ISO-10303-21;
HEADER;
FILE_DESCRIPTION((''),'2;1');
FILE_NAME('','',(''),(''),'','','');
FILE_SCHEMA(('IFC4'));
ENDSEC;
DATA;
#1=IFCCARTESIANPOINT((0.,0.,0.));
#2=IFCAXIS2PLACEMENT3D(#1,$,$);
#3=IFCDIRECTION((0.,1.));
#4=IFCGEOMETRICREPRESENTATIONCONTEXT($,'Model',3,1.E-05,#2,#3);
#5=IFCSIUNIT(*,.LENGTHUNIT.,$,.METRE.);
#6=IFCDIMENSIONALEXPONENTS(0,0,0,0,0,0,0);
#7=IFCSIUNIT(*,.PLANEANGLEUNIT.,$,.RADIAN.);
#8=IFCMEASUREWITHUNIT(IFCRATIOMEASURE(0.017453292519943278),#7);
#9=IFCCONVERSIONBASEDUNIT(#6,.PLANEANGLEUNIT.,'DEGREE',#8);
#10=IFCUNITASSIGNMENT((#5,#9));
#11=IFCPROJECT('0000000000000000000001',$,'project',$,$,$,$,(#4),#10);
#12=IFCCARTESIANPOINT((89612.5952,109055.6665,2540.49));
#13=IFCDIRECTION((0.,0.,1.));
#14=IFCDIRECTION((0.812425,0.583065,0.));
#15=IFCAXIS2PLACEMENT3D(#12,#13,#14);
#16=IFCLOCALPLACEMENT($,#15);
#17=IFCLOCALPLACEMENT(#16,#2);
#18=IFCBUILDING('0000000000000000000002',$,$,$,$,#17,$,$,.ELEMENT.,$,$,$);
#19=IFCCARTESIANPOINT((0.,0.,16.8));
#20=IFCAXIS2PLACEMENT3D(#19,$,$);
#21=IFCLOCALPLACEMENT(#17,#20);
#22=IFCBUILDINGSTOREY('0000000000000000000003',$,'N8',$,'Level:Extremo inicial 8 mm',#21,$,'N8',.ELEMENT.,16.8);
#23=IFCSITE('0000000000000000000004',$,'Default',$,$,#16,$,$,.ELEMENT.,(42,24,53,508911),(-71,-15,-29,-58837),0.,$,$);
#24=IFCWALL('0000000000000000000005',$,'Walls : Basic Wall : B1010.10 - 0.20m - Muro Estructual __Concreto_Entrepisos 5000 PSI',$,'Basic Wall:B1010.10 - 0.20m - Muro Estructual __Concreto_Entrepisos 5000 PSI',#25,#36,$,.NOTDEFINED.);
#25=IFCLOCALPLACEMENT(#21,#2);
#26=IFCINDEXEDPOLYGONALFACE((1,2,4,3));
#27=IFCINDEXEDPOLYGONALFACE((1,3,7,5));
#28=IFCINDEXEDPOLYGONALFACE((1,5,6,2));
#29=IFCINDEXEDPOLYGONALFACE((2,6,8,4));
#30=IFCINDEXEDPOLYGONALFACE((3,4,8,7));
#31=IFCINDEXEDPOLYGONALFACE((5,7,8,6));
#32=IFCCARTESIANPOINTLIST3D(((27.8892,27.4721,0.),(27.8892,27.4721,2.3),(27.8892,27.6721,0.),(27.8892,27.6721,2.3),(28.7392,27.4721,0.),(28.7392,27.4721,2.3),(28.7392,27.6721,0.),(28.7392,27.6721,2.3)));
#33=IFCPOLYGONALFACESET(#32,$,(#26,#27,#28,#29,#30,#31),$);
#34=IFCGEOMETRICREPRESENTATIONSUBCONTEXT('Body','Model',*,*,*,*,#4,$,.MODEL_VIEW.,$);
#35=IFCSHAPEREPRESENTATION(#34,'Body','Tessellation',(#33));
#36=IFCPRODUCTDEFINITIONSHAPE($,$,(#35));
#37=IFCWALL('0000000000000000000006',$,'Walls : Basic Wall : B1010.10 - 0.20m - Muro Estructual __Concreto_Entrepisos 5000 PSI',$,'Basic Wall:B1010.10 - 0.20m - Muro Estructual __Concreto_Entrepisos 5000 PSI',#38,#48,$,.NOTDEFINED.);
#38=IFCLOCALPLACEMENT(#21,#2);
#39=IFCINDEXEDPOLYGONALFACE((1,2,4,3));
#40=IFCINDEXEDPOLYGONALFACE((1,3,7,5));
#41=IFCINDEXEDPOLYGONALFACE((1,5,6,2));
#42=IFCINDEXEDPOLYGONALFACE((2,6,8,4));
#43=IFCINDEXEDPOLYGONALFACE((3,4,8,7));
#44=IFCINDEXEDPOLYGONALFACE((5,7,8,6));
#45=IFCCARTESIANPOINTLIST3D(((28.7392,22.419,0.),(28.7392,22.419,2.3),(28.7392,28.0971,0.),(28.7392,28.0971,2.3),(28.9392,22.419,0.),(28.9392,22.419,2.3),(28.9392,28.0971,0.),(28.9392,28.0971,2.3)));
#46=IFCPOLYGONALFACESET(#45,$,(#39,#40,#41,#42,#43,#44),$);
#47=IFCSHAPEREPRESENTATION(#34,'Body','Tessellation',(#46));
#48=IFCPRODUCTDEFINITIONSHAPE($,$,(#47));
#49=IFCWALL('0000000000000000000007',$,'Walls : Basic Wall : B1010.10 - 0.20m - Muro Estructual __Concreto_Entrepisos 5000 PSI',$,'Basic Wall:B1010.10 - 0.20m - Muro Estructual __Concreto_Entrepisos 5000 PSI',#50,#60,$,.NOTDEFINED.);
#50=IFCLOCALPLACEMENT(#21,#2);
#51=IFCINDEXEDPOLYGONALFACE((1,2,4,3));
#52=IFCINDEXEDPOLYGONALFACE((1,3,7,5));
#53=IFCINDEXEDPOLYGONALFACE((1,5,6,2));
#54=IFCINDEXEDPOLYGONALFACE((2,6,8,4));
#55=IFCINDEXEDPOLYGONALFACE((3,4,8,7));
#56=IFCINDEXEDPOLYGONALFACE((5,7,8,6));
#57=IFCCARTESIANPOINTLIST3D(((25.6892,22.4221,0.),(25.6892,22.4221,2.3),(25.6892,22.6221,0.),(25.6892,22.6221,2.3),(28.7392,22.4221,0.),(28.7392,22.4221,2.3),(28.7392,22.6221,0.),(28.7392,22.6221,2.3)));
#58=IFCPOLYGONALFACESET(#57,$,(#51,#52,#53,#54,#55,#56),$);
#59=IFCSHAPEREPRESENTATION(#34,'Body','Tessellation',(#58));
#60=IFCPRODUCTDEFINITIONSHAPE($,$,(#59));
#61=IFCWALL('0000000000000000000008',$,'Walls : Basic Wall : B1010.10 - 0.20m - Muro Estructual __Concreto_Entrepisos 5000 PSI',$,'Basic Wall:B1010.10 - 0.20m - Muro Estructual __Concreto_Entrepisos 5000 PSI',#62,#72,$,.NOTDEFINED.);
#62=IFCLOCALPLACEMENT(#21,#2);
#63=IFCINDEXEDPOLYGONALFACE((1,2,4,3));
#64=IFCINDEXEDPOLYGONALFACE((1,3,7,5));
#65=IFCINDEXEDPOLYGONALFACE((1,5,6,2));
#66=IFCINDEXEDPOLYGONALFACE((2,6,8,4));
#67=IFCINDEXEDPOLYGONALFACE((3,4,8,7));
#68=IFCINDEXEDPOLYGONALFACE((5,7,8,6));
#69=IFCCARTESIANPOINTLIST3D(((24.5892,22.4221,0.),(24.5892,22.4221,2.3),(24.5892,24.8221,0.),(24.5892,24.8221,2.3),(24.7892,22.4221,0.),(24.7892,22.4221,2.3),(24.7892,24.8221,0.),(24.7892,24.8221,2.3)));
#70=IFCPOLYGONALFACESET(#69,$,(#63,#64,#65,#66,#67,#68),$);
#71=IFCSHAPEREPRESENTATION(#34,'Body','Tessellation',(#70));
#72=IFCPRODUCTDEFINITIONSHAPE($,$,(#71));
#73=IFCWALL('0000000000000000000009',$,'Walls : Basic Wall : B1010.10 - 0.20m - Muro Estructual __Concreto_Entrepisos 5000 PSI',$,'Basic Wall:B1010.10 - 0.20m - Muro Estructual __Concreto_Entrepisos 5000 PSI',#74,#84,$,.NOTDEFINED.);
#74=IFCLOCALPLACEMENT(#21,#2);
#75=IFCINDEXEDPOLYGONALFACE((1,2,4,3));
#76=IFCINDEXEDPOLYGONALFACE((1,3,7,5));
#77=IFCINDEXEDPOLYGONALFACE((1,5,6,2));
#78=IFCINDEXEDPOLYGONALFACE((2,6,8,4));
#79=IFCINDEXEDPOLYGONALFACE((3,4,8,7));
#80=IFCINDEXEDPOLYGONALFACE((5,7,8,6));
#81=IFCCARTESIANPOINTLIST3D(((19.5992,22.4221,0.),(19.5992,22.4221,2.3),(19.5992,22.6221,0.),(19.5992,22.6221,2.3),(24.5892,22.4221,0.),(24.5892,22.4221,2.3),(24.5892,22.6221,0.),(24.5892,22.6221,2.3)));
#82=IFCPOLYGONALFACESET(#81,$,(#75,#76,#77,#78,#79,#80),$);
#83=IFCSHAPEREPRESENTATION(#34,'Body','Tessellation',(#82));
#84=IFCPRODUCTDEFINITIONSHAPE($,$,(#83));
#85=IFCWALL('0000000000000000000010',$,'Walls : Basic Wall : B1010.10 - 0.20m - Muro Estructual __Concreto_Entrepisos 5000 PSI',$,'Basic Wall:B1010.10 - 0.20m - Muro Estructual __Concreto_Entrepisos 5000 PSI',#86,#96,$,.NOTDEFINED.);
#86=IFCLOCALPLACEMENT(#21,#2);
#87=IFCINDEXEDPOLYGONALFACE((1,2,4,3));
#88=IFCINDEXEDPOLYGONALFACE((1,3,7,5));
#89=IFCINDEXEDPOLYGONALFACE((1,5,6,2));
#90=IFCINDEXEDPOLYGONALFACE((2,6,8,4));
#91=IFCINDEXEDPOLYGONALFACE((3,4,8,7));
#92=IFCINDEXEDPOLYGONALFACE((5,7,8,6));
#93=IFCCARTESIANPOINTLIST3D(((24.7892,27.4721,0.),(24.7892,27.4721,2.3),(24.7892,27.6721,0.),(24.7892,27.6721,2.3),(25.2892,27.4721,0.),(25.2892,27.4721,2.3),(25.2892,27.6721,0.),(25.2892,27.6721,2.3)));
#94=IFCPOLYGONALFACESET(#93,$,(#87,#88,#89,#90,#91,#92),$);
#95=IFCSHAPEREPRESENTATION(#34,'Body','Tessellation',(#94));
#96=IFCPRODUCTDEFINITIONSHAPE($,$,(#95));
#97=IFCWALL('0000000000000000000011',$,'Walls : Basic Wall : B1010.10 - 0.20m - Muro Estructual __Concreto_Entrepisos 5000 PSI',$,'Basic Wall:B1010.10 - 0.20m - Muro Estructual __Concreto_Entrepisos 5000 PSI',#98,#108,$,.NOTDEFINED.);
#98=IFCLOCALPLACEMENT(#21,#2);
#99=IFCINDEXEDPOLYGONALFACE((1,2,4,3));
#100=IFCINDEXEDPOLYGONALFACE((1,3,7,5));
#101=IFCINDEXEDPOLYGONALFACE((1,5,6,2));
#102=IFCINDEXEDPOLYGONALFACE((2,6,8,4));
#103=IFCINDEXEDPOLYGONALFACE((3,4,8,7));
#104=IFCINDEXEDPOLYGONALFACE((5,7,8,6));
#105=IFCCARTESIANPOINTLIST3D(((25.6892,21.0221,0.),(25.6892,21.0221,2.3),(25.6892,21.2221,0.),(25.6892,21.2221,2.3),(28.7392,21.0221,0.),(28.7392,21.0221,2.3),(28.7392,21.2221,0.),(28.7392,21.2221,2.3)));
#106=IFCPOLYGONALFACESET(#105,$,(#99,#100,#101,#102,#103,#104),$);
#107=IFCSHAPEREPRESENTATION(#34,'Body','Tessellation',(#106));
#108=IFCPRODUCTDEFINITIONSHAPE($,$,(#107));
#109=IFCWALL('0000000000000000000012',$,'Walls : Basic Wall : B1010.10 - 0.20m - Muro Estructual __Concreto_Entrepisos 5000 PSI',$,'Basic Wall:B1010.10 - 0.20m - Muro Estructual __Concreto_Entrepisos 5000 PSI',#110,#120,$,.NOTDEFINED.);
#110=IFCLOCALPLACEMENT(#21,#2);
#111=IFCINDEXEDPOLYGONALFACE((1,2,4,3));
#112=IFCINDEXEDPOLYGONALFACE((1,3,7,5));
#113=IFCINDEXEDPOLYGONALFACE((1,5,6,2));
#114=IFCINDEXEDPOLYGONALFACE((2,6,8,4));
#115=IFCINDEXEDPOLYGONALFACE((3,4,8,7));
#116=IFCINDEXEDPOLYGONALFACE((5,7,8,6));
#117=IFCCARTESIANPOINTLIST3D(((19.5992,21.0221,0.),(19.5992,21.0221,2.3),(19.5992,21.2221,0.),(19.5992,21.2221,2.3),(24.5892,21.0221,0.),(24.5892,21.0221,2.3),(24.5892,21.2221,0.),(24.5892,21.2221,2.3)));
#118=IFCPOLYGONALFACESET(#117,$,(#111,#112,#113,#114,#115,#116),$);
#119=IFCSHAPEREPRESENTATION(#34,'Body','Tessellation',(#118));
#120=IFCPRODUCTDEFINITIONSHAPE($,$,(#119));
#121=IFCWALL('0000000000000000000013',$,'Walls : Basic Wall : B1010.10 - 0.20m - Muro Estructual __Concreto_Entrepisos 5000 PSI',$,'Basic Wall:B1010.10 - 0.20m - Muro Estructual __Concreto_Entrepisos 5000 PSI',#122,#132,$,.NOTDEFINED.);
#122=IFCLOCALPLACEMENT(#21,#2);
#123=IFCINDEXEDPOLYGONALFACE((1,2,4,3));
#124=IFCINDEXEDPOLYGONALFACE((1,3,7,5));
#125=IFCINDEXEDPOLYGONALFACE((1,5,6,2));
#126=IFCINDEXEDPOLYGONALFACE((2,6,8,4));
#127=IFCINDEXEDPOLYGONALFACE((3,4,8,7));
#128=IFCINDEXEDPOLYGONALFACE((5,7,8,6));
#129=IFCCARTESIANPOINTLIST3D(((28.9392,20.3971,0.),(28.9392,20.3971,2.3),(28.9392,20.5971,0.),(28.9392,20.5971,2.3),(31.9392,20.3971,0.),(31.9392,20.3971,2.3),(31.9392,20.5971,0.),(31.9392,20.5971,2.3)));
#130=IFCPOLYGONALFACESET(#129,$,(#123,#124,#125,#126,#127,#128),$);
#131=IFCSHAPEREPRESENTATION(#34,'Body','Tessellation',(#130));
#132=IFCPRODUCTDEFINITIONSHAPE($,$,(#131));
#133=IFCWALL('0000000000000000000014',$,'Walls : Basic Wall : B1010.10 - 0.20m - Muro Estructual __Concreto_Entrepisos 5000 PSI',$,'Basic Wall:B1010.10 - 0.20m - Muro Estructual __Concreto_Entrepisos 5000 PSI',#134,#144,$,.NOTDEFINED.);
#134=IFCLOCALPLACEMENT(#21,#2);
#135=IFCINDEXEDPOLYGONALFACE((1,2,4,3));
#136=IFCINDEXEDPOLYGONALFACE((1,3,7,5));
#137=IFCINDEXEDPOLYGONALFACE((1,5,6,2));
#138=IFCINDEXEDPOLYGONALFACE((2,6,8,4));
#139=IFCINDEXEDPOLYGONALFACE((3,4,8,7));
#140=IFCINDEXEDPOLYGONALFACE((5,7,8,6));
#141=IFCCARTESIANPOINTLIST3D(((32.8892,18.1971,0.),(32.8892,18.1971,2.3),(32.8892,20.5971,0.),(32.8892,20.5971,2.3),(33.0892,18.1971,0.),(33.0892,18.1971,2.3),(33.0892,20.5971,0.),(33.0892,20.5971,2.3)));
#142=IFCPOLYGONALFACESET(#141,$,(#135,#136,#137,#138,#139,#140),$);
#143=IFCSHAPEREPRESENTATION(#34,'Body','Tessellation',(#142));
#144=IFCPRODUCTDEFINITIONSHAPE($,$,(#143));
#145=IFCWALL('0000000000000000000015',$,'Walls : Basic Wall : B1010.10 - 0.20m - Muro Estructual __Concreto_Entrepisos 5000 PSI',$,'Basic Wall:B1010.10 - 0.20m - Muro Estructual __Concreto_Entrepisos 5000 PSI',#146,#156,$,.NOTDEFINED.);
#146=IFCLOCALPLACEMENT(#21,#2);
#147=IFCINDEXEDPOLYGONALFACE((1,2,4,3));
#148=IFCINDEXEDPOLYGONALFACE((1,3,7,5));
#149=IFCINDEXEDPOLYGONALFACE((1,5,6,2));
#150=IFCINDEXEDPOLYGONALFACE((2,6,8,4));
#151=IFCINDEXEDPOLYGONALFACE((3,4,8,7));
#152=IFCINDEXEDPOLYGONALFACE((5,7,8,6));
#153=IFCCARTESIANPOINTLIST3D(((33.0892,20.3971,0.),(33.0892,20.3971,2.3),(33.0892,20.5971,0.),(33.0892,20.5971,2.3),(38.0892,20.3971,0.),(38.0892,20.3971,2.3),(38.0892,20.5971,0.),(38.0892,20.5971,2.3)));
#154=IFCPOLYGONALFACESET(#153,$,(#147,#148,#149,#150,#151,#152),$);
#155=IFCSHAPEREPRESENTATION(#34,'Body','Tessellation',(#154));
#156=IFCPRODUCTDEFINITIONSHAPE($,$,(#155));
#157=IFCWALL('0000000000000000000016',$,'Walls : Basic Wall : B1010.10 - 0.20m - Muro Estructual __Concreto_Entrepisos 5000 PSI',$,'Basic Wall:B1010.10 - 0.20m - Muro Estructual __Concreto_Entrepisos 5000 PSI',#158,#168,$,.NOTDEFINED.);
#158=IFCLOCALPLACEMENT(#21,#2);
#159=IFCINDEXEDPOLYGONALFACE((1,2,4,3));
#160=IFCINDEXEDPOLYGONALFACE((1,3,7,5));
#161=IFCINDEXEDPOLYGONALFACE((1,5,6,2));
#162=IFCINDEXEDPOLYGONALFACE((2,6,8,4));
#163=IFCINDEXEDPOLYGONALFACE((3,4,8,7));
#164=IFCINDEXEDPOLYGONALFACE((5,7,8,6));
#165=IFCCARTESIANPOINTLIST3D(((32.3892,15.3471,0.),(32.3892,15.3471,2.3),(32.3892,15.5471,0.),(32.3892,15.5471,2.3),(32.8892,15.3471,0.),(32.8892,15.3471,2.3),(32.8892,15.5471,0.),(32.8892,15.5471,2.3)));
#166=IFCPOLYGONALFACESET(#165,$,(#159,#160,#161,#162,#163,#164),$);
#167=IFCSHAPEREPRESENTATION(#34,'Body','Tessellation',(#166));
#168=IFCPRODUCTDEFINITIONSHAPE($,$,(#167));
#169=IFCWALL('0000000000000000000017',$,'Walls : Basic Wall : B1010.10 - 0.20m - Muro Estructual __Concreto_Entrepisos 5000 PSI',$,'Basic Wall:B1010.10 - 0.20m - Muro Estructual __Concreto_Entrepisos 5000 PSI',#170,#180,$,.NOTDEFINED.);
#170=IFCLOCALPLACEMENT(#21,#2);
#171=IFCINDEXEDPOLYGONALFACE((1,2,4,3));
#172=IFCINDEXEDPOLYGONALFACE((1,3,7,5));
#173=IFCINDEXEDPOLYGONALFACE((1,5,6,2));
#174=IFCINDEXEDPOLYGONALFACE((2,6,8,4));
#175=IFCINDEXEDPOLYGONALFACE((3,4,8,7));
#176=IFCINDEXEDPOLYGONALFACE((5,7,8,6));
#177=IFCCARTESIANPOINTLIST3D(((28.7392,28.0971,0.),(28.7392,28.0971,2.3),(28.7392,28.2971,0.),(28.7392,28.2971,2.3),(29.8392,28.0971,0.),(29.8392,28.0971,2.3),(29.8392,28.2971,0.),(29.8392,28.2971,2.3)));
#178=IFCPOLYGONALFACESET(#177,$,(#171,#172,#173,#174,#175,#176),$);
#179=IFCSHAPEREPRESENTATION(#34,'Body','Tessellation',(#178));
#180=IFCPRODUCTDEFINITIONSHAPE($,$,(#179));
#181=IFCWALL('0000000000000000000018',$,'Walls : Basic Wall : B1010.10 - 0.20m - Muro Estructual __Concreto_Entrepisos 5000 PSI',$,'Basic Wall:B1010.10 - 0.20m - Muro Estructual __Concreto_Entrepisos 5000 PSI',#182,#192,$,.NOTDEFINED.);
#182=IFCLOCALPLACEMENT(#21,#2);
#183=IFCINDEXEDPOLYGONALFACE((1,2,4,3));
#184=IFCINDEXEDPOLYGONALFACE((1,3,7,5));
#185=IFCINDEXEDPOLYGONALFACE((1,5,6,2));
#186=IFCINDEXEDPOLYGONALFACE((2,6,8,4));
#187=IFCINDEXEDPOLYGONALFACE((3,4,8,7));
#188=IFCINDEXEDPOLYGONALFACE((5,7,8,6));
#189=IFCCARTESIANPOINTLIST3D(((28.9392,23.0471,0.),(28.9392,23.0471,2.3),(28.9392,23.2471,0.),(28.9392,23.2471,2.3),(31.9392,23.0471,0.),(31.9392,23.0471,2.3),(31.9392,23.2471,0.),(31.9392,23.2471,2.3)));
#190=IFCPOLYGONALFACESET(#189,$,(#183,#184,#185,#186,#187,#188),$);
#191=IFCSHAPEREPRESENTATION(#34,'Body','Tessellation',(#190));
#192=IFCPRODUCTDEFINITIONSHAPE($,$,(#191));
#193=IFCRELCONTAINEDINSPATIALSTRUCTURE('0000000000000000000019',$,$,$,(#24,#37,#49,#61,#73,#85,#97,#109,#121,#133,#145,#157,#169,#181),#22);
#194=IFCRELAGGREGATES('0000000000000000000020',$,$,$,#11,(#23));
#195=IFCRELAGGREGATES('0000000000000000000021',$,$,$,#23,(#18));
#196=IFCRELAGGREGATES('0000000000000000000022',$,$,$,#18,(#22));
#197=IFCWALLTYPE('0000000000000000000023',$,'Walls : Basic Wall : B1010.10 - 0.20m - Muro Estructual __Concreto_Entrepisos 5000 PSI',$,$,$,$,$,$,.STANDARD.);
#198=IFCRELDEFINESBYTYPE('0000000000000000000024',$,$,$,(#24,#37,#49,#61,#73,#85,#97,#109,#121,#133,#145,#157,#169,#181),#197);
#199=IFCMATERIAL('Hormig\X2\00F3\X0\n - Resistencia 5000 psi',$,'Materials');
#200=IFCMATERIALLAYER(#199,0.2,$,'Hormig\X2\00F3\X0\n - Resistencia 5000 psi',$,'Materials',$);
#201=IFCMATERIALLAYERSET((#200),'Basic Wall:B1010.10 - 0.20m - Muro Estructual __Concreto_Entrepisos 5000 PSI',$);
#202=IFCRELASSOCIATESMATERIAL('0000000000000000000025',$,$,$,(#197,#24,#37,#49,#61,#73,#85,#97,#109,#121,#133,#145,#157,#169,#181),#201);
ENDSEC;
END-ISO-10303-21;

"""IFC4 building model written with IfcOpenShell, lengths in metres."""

from ifc_helpers import new_model, entity, si_unit, converted_unit, direction, frame, frame_2d, origin, place, context, subcontext, project, spatial, rectangle, extrude, material, layer, layer_set, layer_usage, type_object, element, save


model = new_model("IFC4")

# Units and contexts
model_context = context("Model", 3, precision=1e-05, world=origin(), true_north=direction((0.0, 1.0)))
body_context = subcontext(model_context, "Body", "Model", "MODEL_VIEW")
ifc_project = project(units=[si_unit("LENGTHUNIT", "METRE"), converted_unit("PLANEANGLEUNIT", "DEGREE", entity("IfcRatioMeasure", 0.017453292519943278), si_unit("PLANEANGLEUNIT", "RADIAN"), dimensions=[0, 0, 0, 0, 0, 0, 0])], contexts=[model_context])

# Site, building, storey
site_placement = place(None, frame((89612.5952, 109055.6665, 2540.49), z_axis=(0.0, 0.0, 1.0), x_axis=(0.812425, 0.583065, 0.0)))
site = spatial("IfcSite", under=ifc_project, at=site_placement, Name="Default", CompositionType="ELEMENT", RefLatitude=(42, 24, 53, 508911), RefLongitude=(-71, -15, -29, -58837), RefElevation=0.0)
building_placement = place(site_placement, origin())
building = spatial("IfcBuilding", under=site, at=building_placement, CompositionType="ELEMENT")
storey_placement = place(building_placement, frame((0.0, 0.0, 16.8)))
storey = spatial("IfcBuildingStorey", under=building, at=storey_placement, Name="N8", ObjectType="Level:Extremo inicial 8 mm", LongName="N8", CompositionType="ELEMENT", Elevation=16.8)

# Walls
ifc_material = material(Name="Hormigón - Resistencia 5000 psi", Category="Materials")
ifc_layer_1 = layer(ifc_material, 0.2, Name="Hormigón - Resistencia 5000 psi", Category="Materials")
ifc_layer_set_1 = layer_set([ifc_layer_1], Name="Basic Wall:B1010.10 - 0.20m - Muro Estructual __Concreto_Entrepisos 5000 PSI")
ifc_layer_usage_1 = layer_usage(ifc_layer_set_1, "AXIS2", "NEGATIVE", 0.1)
wall_type_1 = type_object("IfcWallType", Name="Walls : Basic Wall : B1010.10 - 0.20m - Muro Estructual __Concreto_Entrepisos 5000 PSI", PredefinedType="STANDARD", material=ifc_layer_set_1)
wall_1_placement = place(storey_placement, frame((27.8892, 27.5721, 0.0)))
element("IfcWall", 1, at=wall_1_placement, inside=storey, type_object=wall_type_1, material=ifc_layer_usage_1, Name="Walls : Basic Wall : B1010.10 - 0.20m - Muro Estructual __Concreto_Entrepisos 5000 PSI", ObjectType="Basic Wall:B1010.10 - 0.20m - Muro Estructual __Concreto_Entrepisos 5000 PSI", PredefinedType="NOTDEFINED", context=body_context, shape_type="SweptSolid", body=[
    extrude(rectangle(XDim=0.85, YDim=0.2, at=frame_2d((0.425, 0.0), x_axis=(-1.0, 0.0))), origin(), (0.0, 0.0, 1.0), 2.3),
])
ifc_layer_usage_2 = layer_usage(ifc_layer_set_1, "AXIS2", "NEGATIVE", 0.1)
wall_2_placement = place(storey_placement, frame((28.8392, 28.0971, 0.0), z_axis=(0.0, 0.0, 1.0), x_axis=(0.0, -1.0, 0.0)))
element("IfcWall", 2, at=wall_2_placement, inside=storey, type_object=wall_type_1, material=ifc_layer_usage_2, Name="Walls : Basic Wall : B1010.10 - 0.20m - Muro Estructual __Concreto_Entrepisos 5000 PSI", ObjectType="Basic Wall:B1010.10 - 0.20m - Muro Estructual __Concreto_Entrepisos 5000 PSI", PredefinedType="NOTDEFINED", context=body_context, shape_type="SweptSolid", body=[
    extrude(rectangle(XDim=5.6781, YDim=0.2, at=frame_2d((2.839, 0.0), x_axis=(-1.0, 0.0))), origin(), (0.0, 0.0, 1.0), 2.3),
])
ifc_layer_usage_3 = layer_usage(ifc_layer_set_1, "AXIS2", "NEGATIVE", 0.1)
wall_3_placement = place(storey_placement, frame((28.7392, 22.5221, 0.0), z_axis=(0.0, 0.0, 1.0), x_axis=(-1.0, 0.0, 0.0)))
element("IfcWall", 3, at=wall_3_placement, inside=storey, type_object=wall_type_1, material=ifc_layer_usage_3, Name="Walls : Basic Wall : B1010.10 - 0.20m - Muro Estructual __Concreto_Entrepisos 5000 PSI", ObjectType="Basic Wall:B1010.10 - 0.20m - Muro Estructual __Concreto_Entrepisos 5000 PSI", PredefinedType="NOTDEFINED", context=body_context, shape_type="SweptSolid", body=[
    extrude(rectangle(XDim=3.05, YDim=0.2, at=frame_2d((1.525, 0.0), x_axis=(-1.0, 0.0))), origin(), (0.0, 0.0, 1.0), 2.3),
])
ifc_layer_usage_4 = layer_usage(ifc_layer_set_1, "AXIS2", "NEGATIVE", 0.1)
wall_4_placement = place(storey_placement, frame((24.6892, 24.8221, 0.0), z_axis=(0.0, 0.0, 1.0), x_axis=(0.0, -1.0, 0.0)))
element("IfcWall", 4, at=wall_4_placement, inside=storey, type_object=wall_type_1, material=ifc_layer_usage_4, Name="Walls : Basic Wall : B1010.10 - 0.20m - Muro Estructual __Concreto_Entrepisos 5000 PSI", ObjectType="Basic Wall:B1010.10 - 0.20m - Muro Estructual __Concreto_Entrepisos 5000 PSI", PredefinedType="NOTDEFINED", context=body_context, shape_type="SweptSolid", body=[
    extrude(rectangle(XDim=2.4, YDim=0.2, at=frame_2d((1.2, 0.0), x_axis=(-1.0, 0.0))), origin(), (0.0, 0.0, 1.0), 2.3),
])
ifc_layer_usage_5 = layer_usage(ifc_layer_set_1, "AXIS2", "NEGATIVE", 0.1)
wall_5_placement = place(storey_placement, frame((24.5892, 22.5221, 0.0), z_axis=(0.0, 0.0, 1.0), x_axis=(-1.0, 0.0, 0.0)))
element("IfcWall", 5, at=wall_5_placement, inside=storey, type_object=wall_type_1, material=ifc_layer_usage_5, Name="Walls : Basic Wall : B1010.10 - 0.20m - Muro Estructual __Concreto_Entrepisos 5000 PSI", ObjectType="Basic Wall:B1010.10 - 0.20m - Muro Estructual __Concreto_Entrepisos 5000 PSI", PredefinedType="NOTDEFINED", context=body_context, shape_type="SweptSolid", body=[
    extrude(rectangle(XDim=4.99, YDim=0.2, at=frame_2d((2.495, 0.0), x_axis=(-1.0, 0.0))), origin(), (0.0, 0.0, 1.0), 2.3),
])
ifc_layer_usage_6 = layer_usage(ifc_layer_set_1, "AXIS2", "NEGATIVE", 0.1)
wall_6_placement = place(storey_placement, frame((25.2892, 27.5721, 0.0), z_axis=(0.0, 0.0, 1.0), x_axis=(-1.0, 0.0, 0.0)))
element("IfcWall", 6, at=wall_6_placement, inside=storey, type_object=wall_type_1, material=ifc_layer_usage_6, Name="Walls : Basic Wall : B1010.10 - 0.20m - Muro Estructual __Concreto_Entrepisos 5000 PSI", ObjectType="Basic Wall:B1010.10 - 0.20m - Muro Estructual __Concreto_Entrepisos 5000 PSI", PredefinedType="NOTDEFINED", context=body_context, shape_type="SweptSolid", body=[
    extrude(rectangle(XDim=0.5, YDim=0.2, at=frame_2d((0.25, 0.0), x_axis=(-1.0, 0.0))), origin(), (0.0, 0.0, 1.0), 2.3),
])
ifc_layer_usage_7 = layer_usage(ifc_layer_set_1, "AXIS2", "POSITIVE", -0.1)
wall_7_placement = place(storey_placement, frame((28.7392, 21.1221, 0.0), z_axis=(0.0, 0.0, 1.0), x_axis=(-1.0, 0.0, 0.0)))
element("IfcWall", 7, at=wall_7_placement, inside=storey, type_object=wall_type_1, material=ifc_layer_usage_7, Name="Walls : Basic Wall : B1010.10 - 0.20m - Muro Estructual __Concreto_Entrepisos 5000 PSI", ObjectType="Basic Wall:B1010.10 - 0.20m - Muro Estructual __Concreto_Entrepisos 5000 PSI", PredefinedType="NOTDEFINED", context=body_context, shape_type="SweptSolid", body=[
    extrude(rectangle(XDim=3.05, YDim=0.2, at=frame_2d((1.525, 0.0), x_axis=(-1.0, 0.0))), origin(), (0.0, 0.0, 1.0), 2.3),
])
ifc_layer_usage_8 = layer_usage(ifc_layer_set_1, "AXIS2", "POSITIVE", -0.1)
wall_8_placement = place(storey_placement, frame((24.5892, 21.1221, 0.0), z_axis=(0.0, 0.0, 1.0), x_axis=(-1.0, 0.0, 0.0)))
element("IfcWall", 8, at=wall_8_placement, inside=storey, type_object=wall_type_1, material=ifc_layer_usage_8, Name="Walls : Basic Wall : B1010.10 - 0.20m - Muro Estructual __Concreto_Entrepisos 5000 PSI", ObjectType="Basic Wall:B1010.10 - 0.20m - Muro Estructual __Concreto_Entrepisos 5000 PSI", PredefinedType="NOTDEFINED", context=body_context, shape_type="SweptSolid", body=[
    extrude(rectangle(XDim=4.99, YDim=0.2, at=frame_2d((2.495, 0.0), x_axis=(-1.0, 0.0))), origin(), (0.0, 0.0, 1.0), 2.3),
])
ifc_layer_usage_9 = layer_usage(ifc_layer_set_1, "AXIS2", "NEGATIVE", 0.1)
wall_9_placement = place(storey_placement, frame((28.9392, 20.4971, 0.0)))
element("IfcWall", 9, at=wall_9_placement, inside=storey, type_object=wall_type_1, material=ifc_layer_usage_9, Name="Walls : Basic Wall : B1010.10 - 0.20m - Muro Estructual __Concreto_Entrepisos 5000 PSI", ObjectType="Basic Wall:B1010.10 - 0.20m - Muro Estructual __Concreto_Entrepisos 5000 PSI", PredefinedType="NOTDEFINED", context=body_context, shape_type="SweptSolid", body=[
    extrude(rectangle(XDim=3.0, YDim=0.2, at=frame_2d((1.5, 0.0), x_axis=(-1.0, 0.0))), origin(), (0.0, 0.0, 1.0), 2.3),
])
ifc_layer_usage_10 = layer_usage(ifc_layer_set_1, "AXIS2", "NEGATIVE", 0.1)
wall_10_placement = place(storey_placement, frame((32.9892, 18.1971, 0.0), z_axis=(0.0, 0.0, 1.0), x_axis=(0.0, 1.0, 0.0)))
element("IfcWall", 10, at=wall_10_placement, inside=storey, type_object=wall_type_1, material=ifc_layer_usage_10, Name="Walls : Basic Wall : B1010.10 - 0.20m - Muro Estructual __Concreto_Entrepisos 5000 PSI", ObjectType="Basic Wall:B1010.10 - 0.20m - Muro Estructual __Concreto_Entrepisos 5000 PSI", PredefinedType="NOTDEFINED", context=body_context, shape_type="SweptSolid", body=[
    extrude(rectangle(XDim=2.4, YDim=0.2, at=frame_2d((1.2, 0.0), x_axis=(-1.0, 0.0))), origin(), (0.0, 0.0, 1.0), 2.3),
])
ifc_layer_usage_11 = layer_usage(ifc_layer_set_1, "AXIS2", "NEGATIVE", 0.1)
wall_11_placement = place(storey_placement, frame((33.0892, 20.4971, 0.0)))
element("IfcWall", 11, at=wall_11_placement, inside=storey, type_object=wall_type_1, material=ifc_layer_usage_11, Name="Walls : Basic Wall : B1010.10 - 0.20m - Muro Estructual __Concreto_Entrepisos 5000 PSI", ObjectType="Basic Wall:B1010.10 - 0.20m - Muro Estructual __Concreto_Entrepisos 5000 PSI", PredefinedType="NOTDEFINED", context=body_context, shape_type="SweptSolid", body=[
    extrude(rectangle(XDim=5.0, YDim=0.2, at=frame_2d((2.5, 0.0), x_axis=(-1.0, 0.0))), origin(), (0.0, 0.0, 1.0), 2.3),
])
ifc_layer_usage_12 = layer_usage(ifc_layer_set_1, "AXIS2", "NEGATIVE", 0.1)
wall_12_placement = place(storey_placement, frame((32.3892, 15.4471, 0.0)))
element("IfcWall", 12, at=wall_12_placement, inside=storey, type_object=wall_type_1, material=ifc_layer_usage_12, Name="Walls : Basic Wall : B1010.10 - 0.20m - Muro Estructual __Concreto_Entrepisos 5000 PSI", ObjectType="Basic Wall:B1010.10 - 0.20m - Muro Estructual __Concreto_Entrepisos 5000 PSI", PredefinedType="NOTDEFINED", context=body_context, shape_type="SweptSolid", body=[
    extrude(rectangle(XDim=0.5, YDim=0.2, at=frame_2d((0.25, 0.0), x_axis=(-1.0, 0.0))), origin(), (0.0, 0.0, 1.0), 2.3),
])
ifc_layer_usage_13 = layer_usage(ifc_layer_set_1, "AXIS2", "POSITIVE", -0.1)
wall_13_placement = place(storey_placement, frame((29.8392, 28.1971, 0.0), z_axis=(0.0, 0.0, 1.0), x_axis=(-1.0, 0.0, 0.0)))
element("IfcWall", 13, at=wall_13_placement, inside=storey, type_object=wall_type_1, material=ifc_layer_usage_13, Name="Walls : Basic Wall : B1010.10 - 0.20m - Muro Estructual __Concreto_Entrepisos 5000 PSI", ObjectType="Basic Wall:B1010.10 - 0.20m - Muro Estructual __Concreto_Entrepisos 5000 PSI", PredefinedType="NOTDEFINED", context=body_context, shape_type="SweptSolid", body=[
    extrude(rectangle(XDim=1.1, YDim=0.2, at=frame_2d((0.55, 0.0), x_axis=(-1.0, 0.0))), origin(), (0.0, 0.0, 1.0), 2.3),
])
ifc_layer_usage_14 = layer_usage(ifc_layer_set_1, "AXIS2", "POSITIVE", -0.1)
wall_14_placement = place(storey_placement, frame((28.9392, 23.1471, 0.0)))
element("IfcWall", 14, at=wall_14_placement, inside=storey, type_object=wall_type_1, material=ifc_layer_usage_14, Name="Walls : Basic Wall : B1010.10 - 0.20m - Muro Estructual __Concreto_Entrepisos 5000 PSI", ObjectType="Basic Wall:B1010.10 - 0.20m - Muro Estructual __Concreto_Entrepisos 5000 PSI", PredefinedType="NOTDEFINED", context=body_context, shape_type="SweptSolid", body=[
    extrude(rectangle(XDim=3.0, YDim=0.2, at=frame_2d((1.5, 0.0), x_axis=(-1.0, 0.0))), origin(), (0.0, 0.0, 1.0), 2.3),
])

save(model, "model.ifc")
